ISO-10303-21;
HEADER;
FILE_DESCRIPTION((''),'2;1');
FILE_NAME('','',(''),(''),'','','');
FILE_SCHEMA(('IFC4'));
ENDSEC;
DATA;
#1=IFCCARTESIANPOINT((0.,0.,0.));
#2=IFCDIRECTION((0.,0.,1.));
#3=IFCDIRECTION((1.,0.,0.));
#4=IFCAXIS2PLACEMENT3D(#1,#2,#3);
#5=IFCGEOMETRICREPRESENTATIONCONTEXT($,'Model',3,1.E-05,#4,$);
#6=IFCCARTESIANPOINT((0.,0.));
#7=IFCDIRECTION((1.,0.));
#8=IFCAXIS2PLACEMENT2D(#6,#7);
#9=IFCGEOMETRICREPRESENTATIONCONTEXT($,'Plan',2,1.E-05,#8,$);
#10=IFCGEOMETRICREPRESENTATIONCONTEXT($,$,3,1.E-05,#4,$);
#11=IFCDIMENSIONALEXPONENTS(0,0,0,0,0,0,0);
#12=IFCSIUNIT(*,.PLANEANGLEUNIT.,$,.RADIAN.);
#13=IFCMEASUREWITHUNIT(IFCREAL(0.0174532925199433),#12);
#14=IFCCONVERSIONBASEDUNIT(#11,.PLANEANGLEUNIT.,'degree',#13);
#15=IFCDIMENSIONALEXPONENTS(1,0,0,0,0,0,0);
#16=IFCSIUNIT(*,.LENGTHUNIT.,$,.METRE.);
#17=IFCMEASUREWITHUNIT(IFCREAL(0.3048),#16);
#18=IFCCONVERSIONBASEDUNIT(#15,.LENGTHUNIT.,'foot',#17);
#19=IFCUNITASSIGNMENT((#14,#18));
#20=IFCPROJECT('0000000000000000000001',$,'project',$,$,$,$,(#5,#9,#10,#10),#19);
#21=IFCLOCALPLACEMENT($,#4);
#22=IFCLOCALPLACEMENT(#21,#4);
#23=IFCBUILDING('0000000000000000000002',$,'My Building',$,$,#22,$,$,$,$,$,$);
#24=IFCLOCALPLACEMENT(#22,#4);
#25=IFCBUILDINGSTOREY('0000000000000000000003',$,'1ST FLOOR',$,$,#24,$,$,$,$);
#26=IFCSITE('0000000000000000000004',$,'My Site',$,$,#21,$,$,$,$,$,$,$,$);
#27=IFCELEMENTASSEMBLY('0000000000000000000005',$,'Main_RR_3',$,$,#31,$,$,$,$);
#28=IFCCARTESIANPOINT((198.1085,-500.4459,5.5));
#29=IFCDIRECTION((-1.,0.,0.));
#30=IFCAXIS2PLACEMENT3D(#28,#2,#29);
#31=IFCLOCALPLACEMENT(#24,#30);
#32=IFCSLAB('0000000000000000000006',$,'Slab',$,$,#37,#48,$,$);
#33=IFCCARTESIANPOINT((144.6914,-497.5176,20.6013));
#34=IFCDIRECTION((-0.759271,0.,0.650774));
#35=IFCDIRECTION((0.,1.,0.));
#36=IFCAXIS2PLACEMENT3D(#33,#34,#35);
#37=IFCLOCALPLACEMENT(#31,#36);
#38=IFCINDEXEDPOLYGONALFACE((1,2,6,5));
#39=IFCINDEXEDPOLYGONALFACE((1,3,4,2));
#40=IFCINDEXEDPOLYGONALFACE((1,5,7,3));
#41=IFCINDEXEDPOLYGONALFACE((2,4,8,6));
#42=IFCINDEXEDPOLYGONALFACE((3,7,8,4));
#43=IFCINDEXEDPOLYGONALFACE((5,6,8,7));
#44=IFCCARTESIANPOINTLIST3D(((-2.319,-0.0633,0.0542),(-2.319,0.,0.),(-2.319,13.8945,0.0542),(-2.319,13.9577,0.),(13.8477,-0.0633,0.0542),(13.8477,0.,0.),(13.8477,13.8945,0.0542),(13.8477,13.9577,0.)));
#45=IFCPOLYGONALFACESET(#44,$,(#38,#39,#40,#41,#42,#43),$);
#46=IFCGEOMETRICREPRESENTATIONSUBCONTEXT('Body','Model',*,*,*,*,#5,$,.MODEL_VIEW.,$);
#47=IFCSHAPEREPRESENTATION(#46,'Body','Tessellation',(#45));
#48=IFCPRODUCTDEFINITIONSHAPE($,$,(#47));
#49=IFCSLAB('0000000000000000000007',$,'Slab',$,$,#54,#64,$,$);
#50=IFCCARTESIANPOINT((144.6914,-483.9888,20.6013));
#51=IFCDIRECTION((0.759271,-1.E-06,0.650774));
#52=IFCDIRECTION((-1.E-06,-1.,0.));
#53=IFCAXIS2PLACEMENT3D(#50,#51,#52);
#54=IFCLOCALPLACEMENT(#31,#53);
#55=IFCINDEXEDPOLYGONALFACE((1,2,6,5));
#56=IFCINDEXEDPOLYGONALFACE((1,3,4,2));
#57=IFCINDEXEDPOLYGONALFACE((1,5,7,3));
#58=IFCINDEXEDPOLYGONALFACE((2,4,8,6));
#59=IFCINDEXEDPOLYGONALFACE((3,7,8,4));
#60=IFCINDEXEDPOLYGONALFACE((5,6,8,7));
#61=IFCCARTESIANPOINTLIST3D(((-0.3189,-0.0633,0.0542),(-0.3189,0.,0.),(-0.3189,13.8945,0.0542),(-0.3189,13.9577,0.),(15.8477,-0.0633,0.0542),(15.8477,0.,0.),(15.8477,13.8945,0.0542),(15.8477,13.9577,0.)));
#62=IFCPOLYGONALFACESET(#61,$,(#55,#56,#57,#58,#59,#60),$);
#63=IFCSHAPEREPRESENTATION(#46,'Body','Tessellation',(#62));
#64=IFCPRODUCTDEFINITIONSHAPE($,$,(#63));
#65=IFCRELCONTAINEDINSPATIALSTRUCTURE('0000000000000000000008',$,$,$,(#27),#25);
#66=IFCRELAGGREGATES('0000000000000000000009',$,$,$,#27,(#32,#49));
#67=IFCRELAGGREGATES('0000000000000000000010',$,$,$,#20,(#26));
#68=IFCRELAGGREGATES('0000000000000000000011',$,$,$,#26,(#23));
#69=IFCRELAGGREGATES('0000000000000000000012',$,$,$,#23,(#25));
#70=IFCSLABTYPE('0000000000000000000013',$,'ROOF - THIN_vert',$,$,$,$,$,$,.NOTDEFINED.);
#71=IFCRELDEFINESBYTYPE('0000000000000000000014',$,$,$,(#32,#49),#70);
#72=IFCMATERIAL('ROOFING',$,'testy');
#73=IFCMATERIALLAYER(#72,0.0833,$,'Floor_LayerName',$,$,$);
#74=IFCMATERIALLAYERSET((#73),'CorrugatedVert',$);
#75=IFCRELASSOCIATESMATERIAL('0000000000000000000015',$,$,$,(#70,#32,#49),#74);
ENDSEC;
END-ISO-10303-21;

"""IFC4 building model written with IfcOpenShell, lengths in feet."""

from ifc_helpers import new_model, entity, si_unit, converted_unit, frame, origin_with_axes, origin_2d_with_axis, place, context, subcontext, project, spatial, line, indexed_curve, outline, extrude, material, layer, layer_set, layer_usage, type_object, element, aggregate, save


model = new_model("IFC4")

# Units and contexts
model_context = context("Model", 3, precision=1e-05, world=origin_with_axes())
plan_context = context("Plan", 2, precision=1e-05, world=origin_2d_with_axis())
context_of_model = context(None, 3, precision=1e-05, world=origin_with_axes())
body_context = subcontext(model_context, "Body", "Model", "MODEL_VIEW")
ifc_project = project(units=[converted_unit("PLANEANGLEUNIT", "degree", entity("IfcReal", 0.0174532925199433), si_unit("PLANEANGLEUNIT", "RADIAN"), dimensions=[0, 0, 0, 0, 0, 0, 0]), converted_unit("LENGTHUNIT", "foot", entity("IfcReal", 0.3048), si_unit("LENGTHUNIT", "METRE"), dimensions=[1, 0, 0, 0, 0, 0, 0])], contexts=[model_context, plan_context, context_of_model, context_of_model])

# Site, building, storey
site_placement = place(None, origin_with_axes())
site = spatial("IfcSite", under=ifc_project, at=site_placement, Name="My Site")
building_placement = place(site_placement, origin_with_axes())
building = spatial("IfcBuilding", under=site, at=building_placement, Name="My Building")
storey_placement = place(building_placement, origin_with_axes())
storey = spatial("IfcBuildingStorey", under=building, at=storey_placement, Name="1ST FLOOR")

# Element assembly, slabs
assembly_1_placement = place(storey_placement, frame((198.1085, -500.4459, 5.5), z_axis=(0.0, 0.0, 1.0), x_axis=(-1.0, 0.0, 0.0)))
assembly_1 = element("IfcElementAssembly", 1, at=assembly_1_placement, inside=storey, Name="Main_RR_3")
ifc_material_1 = material(Name="ROOFING", Category="testy")
ifc_layer_1 = layer(ifc_material_1, 0.0833, Name="Floor_LayerName")
ifc_layer_set_1 = layer_set([ifc_layer_1], Name="CorrugatedVert")
ifc_layer_usage_1 = layer_usage(ifc_layer_set_1, "AXIS3", "POSITIVE", 0.0)
slab_type = type_object("IfcSlabType", Name="ROOF - THIN_vert", PredefinedType="NOTDEFINED", material=ifc_layer_set_1)
slab_1_placement = place(assembly_1_placement, frame((144.6914, -497.5176, 20.6013), z_axis=(-0.759271, 0.0, 0.650774), x_axis=(0.0, 1.0, 0.0)))
slab_1 = element("IfcSlab", 2, at=slab_1_placement, type_object=slab_type, material=ifc_layer_usage_1, Name="Slab", context=body_context, shape_type="SweptSolid", body=[
    extrude(outline(indexed_curve([(13.8477, 13.9577), (13.8477, 0.0), (-2.319, 0.0), (-2.319, 13.9577)], segments=[line(3, 2), line(2, 1), line(1, 4), line(4, 3)], self_intersect=False)), None, (0.0, -0.759271, 0.650774), 0.0833),
])
ifc_layer_usage_2 = layer_usage(ifc_layer_set_1, "AXIS3", "POSITIVE", 0.0)
slab_2_placement = place(assembly_1_placement, frame((144.6914, -483.9888, 20.6013), z_axis=(0.759271, -0.000001, 0.650774), x_axis=(-0.000001, -1.0, 0.0)))
slab_2 = element("IfcSlab", 3, at=slab_2_placement, type_object=slab_type, material=ifc_layer_usage_2, Name="Slab", context=body_context, shape_type="SweptSolid", body=[
    extrude(outline(indexed_curve([(15.8477, 13.9577), (15.8477, 0.0), (-0.3189, 0.0), (-0.3189, 13.9577)], segments=[line(4, 1), line(1, 2), line(2, 3), line(3, 4)], self_intersect=False)), None, (0.0, -0.759271, 0.650774), 0.0833),
])

aggregate(assembly_1, [slab_1, slab_2])

save(model, "model.ifc")
